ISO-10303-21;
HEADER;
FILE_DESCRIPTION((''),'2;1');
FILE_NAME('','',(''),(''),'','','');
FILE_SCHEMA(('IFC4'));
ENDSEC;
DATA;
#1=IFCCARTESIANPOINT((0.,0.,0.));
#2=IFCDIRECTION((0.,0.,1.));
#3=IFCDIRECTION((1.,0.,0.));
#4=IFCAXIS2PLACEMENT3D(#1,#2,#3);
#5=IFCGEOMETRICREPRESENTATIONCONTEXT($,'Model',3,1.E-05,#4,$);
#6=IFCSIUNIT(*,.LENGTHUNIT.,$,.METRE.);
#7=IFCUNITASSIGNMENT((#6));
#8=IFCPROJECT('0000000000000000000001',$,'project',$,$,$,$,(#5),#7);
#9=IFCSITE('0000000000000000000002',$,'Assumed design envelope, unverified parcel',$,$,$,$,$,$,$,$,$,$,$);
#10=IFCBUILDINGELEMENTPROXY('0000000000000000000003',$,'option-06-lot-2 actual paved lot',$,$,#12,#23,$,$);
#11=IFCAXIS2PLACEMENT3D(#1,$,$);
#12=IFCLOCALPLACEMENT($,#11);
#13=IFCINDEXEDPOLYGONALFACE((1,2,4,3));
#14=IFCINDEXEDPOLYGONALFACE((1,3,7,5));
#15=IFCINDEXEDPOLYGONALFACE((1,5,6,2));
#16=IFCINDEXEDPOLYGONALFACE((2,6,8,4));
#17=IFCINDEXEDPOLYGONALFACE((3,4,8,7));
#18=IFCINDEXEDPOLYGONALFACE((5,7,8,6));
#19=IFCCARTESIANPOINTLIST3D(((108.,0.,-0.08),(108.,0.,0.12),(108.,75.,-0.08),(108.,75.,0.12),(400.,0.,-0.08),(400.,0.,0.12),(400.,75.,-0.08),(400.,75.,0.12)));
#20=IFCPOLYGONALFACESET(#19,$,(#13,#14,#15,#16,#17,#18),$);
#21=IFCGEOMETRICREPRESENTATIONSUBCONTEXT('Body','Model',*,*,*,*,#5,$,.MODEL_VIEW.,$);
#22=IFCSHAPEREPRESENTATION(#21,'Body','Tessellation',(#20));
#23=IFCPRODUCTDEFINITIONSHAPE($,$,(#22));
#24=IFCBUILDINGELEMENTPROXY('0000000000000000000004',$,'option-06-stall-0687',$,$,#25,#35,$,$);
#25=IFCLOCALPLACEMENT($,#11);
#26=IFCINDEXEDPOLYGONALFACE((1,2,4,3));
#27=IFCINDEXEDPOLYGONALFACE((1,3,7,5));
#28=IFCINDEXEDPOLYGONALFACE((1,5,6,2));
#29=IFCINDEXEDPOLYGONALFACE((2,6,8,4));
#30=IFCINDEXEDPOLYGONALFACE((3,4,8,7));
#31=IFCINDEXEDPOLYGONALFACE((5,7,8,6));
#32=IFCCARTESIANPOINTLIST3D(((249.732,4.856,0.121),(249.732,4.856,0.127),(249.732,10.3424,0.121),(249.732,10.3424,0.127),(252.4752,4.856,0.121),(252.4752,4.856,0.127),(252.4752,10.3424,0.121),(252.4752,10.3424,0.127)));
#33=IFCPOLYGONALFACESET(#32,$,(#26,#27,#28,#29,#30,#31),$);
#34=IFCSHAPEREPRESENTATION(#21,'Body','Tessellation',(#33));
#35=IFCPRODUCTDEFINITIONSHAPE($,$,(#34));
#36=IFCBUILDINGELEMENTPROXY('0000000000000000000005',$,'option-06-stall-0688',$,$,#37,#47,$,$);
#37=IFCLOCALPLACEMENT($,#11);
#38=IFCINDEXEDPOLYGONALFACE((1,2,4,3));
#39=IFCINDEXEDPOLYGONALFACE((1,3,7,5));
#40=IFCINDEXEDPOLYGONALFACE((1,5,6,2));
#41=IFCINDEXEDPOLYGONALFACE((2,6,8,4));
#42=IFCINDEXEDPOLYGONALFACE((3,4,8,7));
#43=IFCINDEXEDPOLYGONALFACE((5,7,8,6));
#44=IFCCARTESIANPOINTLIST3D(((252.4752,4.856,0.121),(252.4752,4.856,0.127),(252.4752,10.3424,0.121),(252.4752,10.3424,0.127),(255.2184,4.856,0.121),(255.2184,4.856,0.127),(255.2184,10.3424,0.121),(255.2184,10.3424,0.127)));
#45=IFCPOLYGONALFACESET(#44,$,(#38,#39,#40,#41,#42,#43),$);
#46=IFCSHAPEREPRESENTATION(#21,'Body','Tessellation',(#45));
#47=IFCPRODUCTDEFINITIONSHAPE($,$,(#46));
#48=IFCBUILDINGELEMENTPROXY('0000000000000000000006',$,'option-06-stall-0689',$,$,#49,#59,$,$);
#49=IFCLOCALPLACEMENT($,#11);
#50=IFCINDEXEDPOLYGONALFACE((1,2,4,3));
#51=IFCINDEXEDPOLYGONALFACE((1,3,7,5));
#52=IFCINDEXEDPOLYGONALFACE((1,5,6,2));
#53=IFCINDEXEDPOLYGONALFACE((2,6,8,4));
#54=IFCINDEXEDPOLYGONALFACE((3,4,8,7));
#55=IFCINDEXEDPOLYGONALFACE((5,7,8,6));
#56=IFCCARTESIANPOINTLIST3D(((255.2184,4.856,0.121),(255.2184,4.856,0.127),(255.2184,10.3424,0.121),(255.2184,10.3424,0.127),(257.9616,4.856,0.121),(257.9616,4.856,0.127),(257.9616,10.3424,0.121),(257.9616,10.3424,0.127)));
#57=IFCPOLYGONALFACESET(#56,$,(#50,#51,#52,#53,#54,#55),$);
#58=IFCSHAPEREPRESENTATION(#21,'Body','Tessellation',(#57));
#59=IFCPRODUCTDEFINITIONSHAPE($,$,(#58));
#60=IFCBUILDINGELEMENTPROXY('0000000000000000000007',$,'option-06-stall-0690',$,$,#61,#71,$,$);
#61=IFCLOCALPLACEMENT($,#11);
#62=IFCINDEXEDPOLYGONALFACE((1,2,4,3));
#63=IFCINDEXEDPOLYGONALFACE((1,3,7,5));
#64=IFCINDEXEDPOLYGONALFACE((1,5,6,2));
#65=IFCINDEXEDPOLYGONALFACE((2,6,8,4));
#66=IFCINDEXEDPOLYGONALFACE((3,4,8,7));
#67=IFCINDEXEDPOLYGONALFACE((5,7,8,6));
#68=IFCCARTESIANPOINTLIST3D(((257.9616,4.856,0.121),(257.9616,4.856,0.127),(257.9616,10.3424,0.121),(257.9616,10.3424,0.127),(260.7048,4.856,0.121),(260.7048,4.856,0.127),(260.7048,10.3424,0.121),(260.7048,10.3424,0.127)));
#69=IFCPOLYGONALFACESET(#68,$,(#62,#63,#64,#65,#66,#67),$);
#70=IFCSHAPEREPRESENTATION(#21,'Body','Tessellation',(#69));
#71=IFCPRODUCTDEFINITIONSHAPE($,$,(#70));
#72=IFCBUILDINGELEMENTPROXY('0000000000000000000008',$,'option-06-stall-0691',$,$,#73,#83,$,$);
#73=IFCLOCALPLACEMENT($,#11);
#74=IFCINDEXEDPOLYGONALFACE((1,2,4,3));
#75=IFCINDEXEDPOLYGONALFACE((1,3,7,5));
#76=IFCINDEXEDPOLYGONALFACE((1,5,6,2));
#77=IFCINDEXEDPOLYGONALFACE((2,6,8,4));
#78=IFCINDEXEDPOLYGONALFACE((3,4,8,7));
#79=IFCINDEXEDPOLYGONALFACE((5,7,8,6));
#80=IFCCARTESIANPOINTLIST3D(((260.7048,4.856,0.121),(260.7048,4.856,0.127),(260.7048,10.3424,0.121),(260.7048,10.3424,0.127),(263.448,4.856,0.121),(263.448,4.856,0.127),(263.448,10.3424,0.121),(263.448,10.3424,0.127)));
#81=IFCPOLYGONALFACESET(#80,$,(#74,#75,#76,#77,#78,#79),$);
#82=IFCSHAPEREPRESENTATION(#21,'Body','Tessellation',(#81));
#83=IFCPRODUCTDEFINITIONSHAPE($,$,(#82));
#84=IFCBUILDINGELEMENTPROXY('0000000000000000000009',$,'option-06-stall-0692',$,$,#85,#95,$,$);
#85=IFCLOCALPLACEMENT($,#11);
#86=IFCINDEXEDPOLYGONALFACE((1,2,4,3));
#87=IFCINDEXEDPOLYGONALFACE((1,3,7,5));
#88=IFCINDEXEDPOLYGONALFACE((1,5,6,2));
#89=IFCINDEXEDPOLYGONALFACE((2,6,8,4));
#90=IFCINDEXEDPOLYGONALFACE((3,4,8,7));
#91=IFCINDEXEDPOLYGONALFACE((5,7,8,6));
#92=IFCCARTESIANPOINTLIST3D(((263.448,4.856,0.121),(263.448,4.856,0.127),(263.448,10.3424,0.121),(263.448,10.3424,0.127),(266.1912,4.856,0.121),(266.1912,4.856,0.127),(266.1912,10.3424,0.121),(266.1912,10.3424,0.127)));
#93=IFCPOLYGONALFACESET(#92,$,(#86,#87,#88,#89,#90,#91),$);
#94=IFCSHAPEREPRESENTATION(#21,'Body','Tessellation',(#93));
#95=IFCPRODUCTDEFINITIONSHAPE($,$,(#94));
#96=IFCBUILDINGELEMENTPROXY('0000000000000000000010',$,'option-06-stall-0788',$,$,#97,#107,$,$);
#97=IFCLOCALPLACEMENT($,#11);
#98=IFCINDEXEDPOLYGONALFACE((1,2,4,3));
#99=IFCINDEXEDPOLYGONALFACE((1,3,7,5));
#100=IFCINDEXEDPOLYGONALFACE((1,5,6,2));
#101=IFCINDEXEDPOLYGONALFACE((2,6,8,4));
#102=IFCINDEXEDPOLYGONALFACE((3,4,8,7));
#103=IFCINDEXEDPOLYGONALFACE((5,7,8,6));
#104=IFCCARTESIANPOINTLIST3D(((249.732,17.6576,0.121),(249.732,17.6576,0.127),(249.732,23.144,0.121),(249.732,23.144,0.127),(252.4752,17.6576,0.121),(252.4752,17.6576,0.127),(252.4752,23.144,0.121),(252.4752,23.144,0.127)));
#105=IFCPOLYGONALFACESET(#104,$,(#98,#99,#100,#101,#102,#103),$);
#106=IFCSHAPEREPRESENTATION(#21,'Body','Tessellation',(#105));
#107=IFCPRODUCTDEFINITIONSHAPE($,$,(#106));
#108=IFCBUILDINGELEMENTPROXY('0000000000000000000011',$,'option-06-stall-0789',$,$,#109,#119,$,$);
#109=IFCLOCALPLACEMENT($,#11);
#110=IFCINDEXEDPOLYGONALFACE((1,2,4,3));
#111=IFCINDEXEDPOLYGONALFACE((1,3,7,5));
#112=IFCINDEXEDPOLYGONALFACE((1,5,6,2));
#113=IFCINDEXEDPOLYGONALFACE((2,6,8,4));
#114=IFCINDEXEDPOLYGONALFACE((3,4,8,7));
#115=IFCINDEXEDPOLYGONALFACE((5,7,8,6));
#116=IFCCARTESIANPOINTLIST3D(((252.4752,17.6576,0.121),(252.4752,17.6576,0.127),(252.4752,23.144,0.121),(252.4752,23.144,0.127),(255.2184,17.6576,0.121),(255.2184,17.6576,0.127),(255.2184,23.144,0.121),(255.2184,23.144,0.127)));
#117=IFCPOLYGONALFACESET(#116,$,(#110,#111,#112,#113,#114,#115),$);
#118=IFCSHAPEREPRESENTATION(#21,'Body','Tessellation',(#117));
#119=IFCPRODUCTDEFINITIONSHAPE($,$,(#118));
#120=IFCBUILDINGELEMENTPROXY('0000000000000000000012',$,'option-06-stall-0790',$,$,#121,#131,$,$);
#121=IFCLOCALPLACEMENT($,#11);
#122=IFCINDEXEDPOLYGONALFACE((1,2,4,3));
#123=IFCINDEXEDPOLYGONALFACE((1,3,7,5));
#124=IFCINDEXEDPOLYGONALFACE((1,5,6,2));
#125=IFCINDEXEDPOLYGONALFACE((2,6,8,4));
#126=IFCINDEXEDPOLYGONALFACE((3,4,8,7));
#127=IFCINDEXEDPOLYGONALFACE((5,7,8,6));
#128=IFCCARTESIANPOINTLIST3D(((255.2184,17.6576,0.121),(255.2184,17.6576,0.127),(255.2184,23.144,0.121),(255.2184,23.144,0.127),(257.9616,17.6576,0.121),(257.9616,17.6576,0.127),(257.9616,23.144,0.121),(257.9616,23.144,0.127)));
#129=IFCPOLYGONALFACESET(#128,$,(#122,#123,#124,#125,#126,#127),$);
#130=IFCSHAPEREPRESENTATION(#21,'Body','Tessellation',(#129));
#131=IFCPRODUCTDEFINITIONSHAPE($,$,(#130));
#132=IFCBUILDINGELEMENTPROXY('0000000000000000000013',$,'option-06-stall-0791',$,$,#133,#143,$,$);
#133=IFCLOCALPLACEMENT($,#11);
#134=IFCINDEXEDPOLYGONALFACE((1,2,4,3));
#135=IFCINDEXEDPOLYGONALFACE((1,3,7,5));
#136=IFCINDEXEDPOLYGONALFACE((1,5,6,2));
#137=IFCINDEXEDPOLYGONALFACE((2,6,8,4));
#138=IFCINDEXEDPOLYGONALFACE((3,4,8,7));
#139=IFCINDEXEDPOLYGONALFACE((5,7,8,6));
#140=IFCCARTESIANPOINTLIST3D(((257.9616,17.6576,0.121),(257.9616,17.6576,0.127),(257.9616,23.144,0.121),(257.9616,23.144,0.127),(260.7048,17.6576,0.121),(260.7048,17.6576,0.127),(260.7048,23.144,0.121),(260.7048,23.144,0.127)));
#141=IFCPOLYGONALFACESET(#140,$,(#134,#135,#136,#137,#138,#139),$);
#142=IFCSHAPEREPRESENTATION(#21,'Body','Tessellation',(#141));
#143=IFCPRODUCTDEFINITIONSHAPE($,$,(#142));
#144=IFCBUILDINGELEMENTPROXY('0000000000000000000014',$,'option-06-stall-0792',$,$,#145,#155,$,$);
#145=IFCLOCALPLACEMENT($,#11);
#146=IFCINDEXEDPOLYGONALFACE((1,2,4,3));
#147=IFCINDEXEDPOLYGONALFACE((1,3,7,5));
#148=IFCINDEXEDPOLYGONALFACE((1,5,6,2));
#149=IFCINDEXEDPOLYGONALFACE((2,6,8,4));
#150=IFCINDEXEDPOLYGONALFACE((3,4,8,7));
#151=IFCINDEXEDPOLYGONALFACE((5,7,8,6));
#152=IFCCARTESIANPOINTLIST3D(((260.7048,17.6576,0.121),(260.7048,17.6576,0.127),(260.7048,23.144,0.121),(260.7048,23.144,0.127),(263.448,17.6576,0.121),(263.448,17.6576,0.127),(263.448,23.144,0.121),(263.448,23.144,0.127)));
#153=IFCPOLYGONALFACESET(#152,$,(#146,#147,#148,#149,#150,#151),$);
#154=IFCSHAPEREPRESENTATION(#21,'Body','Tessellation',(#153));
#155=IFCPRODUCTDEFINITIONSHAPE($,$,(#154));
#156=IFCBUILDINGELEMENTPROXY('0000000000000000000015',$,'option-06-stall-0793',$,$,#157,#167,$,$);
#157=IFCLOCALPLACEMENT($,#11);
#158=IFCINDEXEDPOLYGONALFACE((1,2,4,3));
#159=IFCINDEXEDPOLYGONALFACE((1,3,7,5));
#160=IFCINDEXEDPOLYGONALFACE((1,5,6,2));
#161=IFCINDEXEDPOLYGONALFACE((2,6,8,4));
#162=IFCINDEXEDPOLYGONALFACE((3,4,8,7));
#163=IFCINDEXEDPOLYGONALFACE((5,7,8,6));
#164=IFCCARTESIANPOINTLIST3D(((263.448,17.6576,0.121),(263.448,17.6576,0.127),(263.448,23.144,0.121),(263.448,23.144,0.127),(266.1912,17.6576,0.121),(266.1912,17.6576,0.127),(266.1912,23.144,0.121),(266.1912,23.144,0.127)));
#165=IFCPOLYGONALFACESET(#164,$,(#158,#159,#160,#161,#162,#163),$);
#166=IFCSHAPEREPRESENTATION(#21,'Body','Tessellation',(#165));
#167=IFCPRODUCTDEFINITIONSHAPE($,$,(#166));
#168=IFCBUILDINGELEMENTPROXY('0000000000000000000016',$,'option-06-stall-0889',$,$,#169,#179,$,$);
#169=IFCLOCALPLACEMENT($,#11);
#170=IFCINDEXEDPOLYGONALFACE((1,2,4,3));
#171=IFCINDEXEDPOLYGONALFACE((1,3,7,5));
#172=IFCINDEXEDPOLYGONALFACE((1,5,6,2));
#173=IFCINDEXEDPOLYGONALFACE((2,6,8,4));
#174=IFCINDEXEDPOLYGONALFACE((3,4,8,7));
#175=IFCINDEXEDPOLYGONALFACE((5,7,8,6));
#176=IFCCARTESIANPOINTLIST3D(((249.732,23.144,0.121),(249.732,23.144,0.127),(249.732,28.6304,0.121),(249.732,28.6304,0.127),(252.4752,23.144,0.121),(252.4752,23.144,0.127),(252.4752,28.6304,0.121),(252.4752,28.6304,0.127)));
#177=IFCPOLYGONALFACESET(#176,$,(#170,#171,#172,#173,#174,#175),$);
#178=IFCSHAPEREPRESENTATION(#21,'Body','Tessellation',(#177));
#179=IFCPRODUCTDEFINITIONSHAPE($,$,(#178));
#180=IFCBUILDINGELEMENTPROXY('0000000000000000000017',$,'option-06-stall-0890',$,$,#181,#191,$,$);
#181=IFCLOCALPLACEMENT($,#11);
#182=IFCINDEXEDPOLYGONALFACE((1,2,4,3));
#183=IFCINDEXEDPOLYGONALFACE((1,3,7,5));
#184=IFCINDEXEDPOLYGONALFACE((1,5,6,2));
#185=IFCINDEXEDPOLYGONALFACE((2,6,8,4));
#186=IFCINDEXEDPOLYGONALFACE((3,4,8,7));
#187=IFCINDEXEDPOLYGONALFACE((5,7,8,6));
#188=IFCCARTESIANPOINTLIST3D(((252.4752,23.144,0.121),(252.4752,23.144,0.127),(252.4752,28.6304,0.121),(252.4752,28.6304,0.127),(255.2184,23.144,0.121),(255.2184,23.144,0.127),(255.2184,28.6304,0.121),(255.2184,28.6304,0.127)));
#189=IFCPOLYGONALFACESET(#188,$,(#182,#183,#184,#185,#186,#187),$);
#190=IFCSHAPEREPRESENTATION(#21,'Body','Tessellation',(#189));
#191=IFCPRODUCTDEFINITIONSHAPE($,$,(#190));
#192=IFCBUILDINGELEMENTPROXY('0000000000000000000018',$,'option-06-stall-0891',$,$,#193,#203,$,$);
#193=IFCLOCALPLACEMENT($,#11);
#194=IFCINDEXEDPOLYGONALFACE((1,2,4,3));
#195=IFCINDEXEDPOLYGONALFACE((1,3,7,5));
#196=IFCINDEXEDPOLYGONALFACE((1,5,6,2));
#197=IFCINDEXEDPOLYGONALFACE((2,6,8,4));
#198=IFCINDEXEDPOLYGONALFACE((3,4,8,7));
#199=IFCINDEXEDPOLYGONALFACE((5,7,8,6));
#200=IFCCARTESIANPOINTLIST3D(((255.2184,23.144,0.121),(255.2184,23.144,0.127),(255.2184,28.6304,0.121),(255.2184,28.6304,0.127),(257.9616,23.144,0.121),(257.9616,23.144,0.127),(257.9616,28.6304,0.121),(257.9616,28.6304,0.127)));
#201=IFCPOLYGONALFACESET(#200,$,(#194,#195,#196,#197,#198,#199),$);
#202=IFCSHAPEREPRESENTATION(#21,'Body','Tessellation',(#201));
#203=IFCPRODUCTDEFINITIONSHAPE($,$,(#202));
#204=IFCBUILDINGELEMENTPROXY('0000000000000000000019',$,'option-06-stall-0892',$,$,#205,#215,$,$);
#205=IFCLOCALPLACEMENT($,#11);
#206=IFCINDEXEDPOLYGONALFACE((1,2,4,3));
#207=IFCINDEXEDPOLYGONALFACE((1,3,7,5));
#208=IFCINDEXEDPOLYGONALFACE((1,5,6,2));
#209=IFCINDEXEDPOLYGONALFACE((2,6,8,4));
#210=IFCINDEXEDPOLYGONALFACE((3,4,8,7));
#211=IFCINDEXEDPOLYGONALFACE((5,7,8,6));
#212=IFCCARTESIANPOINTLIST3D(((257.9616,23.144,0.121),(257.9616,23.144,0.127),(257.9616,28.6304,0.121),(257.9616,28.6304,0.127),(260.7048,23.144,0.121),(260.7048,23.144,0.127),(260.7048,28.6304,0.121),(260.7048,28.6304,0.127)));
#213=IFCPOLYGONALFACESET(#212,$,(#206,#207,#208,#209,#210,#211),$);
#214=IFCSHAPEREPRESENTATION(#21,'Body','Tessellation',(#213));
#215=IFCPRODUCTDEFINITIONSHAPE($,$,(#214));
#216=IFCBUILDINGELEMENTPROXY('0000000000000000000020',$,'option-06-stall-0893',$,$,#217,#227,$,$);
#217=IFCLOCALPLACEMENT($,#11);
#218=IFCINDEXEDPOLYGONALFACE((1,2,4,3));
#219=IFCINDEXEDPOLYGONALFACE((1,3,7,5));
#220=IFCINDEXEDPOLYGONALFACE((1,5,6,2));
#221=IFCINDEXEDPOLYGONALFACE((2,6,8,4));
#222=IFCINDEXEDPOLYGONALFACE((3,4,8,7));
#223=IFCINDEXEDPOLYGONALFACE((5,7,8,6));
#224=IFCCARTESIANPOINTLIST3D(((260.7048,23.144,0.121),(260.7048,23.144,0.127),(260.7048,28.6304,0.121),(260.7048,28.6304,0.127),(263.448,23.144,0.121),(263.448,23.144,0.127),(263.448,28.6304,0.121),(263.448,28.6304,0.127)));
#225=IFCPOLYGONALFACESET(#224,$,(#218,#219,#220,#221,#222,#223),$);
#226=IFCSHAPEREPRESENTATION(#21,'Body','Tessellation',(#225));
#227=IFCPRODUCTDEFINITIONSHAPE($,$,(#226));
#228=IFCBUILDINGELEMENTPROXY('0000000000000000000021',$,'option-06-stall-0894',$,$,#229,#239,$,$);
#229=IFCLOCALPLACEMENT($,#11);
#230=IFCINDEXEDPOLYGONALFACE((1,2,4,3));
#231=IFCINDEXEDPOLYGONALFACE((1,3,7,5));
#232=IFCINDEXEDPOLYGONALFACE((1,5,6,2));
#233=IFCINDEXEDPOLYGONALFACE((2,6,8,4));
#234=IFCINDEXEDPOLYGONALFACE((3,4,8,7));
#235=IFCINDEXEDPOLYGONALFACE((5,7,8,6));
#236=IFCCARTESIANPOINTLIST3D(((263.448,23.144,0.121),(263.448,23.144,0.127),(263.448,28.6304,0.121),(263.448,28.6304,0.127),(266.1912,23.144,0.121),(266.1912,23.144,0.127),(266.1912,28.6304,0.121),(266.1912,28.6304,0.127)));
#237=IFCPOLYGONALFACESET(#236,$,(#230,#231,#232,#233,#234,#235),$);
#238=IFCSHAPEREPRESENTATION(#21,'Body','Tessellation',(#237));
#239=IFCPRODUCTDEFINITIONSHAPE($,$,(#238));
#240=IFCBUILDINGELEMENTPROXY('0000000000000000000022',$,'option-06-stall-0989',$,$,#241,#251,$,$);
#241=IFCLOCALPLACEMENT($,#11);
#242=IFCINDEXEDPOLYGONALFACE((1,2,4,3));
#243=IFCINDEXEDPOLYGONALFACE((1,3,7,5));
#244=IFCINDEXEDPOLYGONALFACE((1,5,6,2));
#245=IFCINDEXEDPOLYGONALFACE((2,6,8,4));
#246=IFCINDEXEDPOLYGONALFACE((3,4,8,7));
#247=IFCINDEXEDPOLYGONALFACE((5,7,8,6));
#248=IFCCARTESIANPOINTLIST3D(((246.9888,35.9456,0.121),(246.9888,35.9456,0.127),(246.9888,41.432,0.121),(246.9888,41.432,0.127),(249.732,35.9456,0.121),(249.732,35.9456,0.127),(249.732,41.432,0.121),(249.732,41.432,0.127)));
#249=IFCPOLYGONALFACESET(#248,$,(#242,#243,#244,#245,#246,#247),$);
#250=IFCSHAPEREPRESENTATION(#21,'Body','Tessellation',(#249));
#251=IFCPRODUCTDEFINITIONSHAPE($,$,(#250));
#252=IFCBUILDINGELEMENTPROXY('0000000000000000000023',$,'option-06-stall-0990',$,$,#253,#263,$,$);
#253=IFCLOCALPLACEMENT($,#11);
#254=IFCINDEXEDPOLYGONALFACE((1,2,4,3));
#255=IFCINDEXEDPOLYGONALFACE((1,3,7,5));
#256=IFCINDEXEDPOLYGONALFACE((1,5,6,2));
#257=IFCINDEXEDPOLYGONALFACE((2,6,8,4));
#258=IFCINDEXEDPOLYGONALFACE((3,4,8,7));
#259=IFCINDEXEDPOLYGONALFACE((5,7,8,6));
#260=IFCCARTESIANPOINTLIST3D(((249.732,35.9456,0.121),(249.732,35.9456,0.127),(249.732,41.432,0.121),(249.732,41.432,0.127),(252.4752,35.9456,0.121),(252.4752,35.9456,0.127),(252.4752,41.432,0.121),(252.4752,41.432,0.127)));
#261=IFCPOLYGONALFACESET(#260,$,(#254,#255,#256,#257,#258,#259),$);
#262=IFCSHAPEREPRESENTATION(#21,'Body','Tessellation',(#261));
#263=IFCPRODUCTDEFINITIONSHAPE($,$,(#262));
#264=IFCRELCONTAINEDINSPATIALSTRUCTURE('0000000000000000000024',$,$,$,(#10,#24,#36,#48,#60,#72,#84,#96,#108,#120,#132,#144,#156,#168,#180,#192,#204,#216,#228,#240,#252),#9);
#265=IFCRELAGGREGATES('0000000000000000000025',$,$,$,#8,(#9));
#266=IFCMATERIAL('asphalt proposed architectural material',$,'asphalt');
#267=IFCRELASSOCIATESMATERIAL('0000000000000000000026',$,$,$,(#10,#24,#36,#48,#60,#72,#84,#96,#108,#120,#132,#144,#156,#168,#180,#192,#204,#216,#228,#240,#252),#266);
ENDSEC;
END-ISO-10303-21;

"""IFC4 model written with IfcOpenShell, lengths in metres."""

from ifc_helpers import new_model, si_unit, frame, origin_with_axes, place, context, subcontext, project, spatial, rectangle, extrude, material, element, save


model = new_model("IFC4")

# Units and contexts
model_context = context("Model", 3, precision=1e-05, world=origin_with_axes())
body_context = subcontext(model_context, "Body", "Model", "MODEL_VIEW")
ifc_project = project(units=[si_unit("LENGTHUNIT", "METRE")], contexts=[model_context])

# Site
site = spatial("IfcSite", under=ifc_project, Name="Assumed design envelope, unverified parcel")

# Building element proxies
ifc_material = material(Name="asphalt proposed architectural material", Category="asphalt")
proxy_placement = place(None, frame((254.0, 37.5, -0.08), z_axis=(0.0, 0.0, 1.0), x_axis=(1.0, 0.0, 0.0)))
element("IfcBuildingElementProxy", 1, at=proxy_placement, inside=site, material=ifc_material, Name="option-06-lot-2 actual paved lot", context=body_context, shape_type="SweptSolid", body=[
    extrude(rectangle(XDim=292.0, YDim=75.0), origin_with_axes(), (0.0, 0.0, 1.0), 0.2),
])
for number, where, z_axis, x_axis, name in (
    (2, (251.1036, 7.5992, 0.121), (0.0, 0.0, 1.0), (1.0, 0.0, 0.0), "option-06-stall-0687"),
    (3, (253.8468, 7.5992, 0.121), (0.0, 0.0, 1.0), (1.0, 0.0, 0.0), "option-06-stall-0688"),
    (4, (256.59, 7.5992, 0.121), (0.0, 0.0, 1.0), (1.0, 0.0, 0.0), "option-06-stall-0689"),
    (5, (259.3332, 7.5992, 0.121), (0.0, 0.0, 1.0), (1.0, 0.0, 0.0), "option-06-stall-0690"),
    (6, (262.0764, 7.5992, 0.121), (0.0, 0.0, 1.0), (1.0, 0.0, 0.0), "option-06-stall-0691"),
    (7, (264.8196, 7.5992, 0.121), (0.0, 0.0, 1.0), (1.0, 0.0, 0.0), "option-06-stall-0692"),
):
    element("IfcBuildingElementProxy", number, at=place(None, frame(where, z_axis=z_axis, x_axis=x_axis)), inside=site, material=ifc_material, Name=name, context=body_context, shape_type="SweptSolid", body=[
        extrude(rectangle(XDim=2.7432, YDim=5.4864), origin_with_axes(), (0.0, 0.0, 1.0), 0.006),
    ])
for number, where, z_axis, x_axis, name in (
    (8, (251.1036, 20.4008, 0.121), (0.0, 0.0, 1.0), (1.0, 0.0, 0.0), "option-06-stall-0788"),
    (9, (253.8468, 20.4008, 0.121), (0.0, 0.0, 1.0), (1.0, 0.0, 0.0), "option-06-stall-0789"),
    (10, (256.59, 20.4008, 0.121), (0.0, 0.0, 1.0), (1.0, 0.0, 0.0), "option-06-stall-0790"),
    (11, (259.3332, 20.4008, 0.121), (0.0, 0.0, 1.0), (1.0, 0.0, 0.0), "option-06-stall-0791"),
    (12, (262.0764, 20.4008, 0.121), (0.0, 0.0, 1.0), (1.0, 0.0, 0.0), "option-06-stall-0792"),
    (13, (264.8196, 20.4008, 0.121), (0.0, 0.0, 1.0), (1.0, 0.0, 0.0), "option-06-stall-0793"),
    (14, (251.1036, 25.8872, 0.121), (0.0, 0.0, 1.0), (1.0, 0.0, 0.0), "option-06-stall-0889"),
    (15, (253.8468, 25.8872, 0.121), (0.0, 0.0, 1.0), (1.0, 0.0, 0.0), "option-06-stall-0890"),
    (16, (256.59, 25.8872, 0.121), (0.0, 0.0, 1.0), (1.0, 0.0, 0.0), "option-06-stall-0891"),
    (17, (259.3332, 25.8872, 0.121), (0.0, 0.0, 1.0), (1.0, 0.0, 0.0), "option-06-stall-0892"),
    (18, (262.0764, 25.8872, 0.121), (0.0, 0.0, 1.0), (1.0, 0.0, 0.0), "option-06-stall-0893"),
    (19, (264.8196, 25.8872, 0.121), (0.0, 0.0, 1.0), (1.0, 0.0, 0.0), "option-06-stall-0894"),
):
    element("IfcBuildingElementProxy", number, at=place(None, frame(where, z_axis=z_axis, x_axis=x_axis)), inside=site, material=ifc_material, Name=name, context=body_context, shape_type="SweptSolid", body=[
        extrude(rectangle(XDim=2.7432, YDim=5.4864), origin_with_axes(), (0.0, 0.0, 1.0), 0.006),
    ])
for number, where, z_axis, x_axis, name in (
    (20, (248.3604, 38.6888, 0.121), (0.0, 0.0, 1.0), (1.0, 0.0, 0.0), "option-06-stall-0989"),
    (21, (251.1036, 38.6888, 0.121), (0.0, 0.0, 1.0), (1.0, 0.0, 0.0), "option-06-stall-0990"),
):
    element("IfcBuildingElementProxy", number, at=place(None, frame(where, z_axis=z_axis, x_axis=x_axis)), inside=site, material=ifc_material, Name=name, context=body_context, shape_type="SweptSolid", body=[
        extrude(rectangle(XDim=2.7432, YDim=5.4864), origin_with_axes(), (0.0, 0.0, 1.0), 0.006),
    ])

save(model, "model.ifc")
